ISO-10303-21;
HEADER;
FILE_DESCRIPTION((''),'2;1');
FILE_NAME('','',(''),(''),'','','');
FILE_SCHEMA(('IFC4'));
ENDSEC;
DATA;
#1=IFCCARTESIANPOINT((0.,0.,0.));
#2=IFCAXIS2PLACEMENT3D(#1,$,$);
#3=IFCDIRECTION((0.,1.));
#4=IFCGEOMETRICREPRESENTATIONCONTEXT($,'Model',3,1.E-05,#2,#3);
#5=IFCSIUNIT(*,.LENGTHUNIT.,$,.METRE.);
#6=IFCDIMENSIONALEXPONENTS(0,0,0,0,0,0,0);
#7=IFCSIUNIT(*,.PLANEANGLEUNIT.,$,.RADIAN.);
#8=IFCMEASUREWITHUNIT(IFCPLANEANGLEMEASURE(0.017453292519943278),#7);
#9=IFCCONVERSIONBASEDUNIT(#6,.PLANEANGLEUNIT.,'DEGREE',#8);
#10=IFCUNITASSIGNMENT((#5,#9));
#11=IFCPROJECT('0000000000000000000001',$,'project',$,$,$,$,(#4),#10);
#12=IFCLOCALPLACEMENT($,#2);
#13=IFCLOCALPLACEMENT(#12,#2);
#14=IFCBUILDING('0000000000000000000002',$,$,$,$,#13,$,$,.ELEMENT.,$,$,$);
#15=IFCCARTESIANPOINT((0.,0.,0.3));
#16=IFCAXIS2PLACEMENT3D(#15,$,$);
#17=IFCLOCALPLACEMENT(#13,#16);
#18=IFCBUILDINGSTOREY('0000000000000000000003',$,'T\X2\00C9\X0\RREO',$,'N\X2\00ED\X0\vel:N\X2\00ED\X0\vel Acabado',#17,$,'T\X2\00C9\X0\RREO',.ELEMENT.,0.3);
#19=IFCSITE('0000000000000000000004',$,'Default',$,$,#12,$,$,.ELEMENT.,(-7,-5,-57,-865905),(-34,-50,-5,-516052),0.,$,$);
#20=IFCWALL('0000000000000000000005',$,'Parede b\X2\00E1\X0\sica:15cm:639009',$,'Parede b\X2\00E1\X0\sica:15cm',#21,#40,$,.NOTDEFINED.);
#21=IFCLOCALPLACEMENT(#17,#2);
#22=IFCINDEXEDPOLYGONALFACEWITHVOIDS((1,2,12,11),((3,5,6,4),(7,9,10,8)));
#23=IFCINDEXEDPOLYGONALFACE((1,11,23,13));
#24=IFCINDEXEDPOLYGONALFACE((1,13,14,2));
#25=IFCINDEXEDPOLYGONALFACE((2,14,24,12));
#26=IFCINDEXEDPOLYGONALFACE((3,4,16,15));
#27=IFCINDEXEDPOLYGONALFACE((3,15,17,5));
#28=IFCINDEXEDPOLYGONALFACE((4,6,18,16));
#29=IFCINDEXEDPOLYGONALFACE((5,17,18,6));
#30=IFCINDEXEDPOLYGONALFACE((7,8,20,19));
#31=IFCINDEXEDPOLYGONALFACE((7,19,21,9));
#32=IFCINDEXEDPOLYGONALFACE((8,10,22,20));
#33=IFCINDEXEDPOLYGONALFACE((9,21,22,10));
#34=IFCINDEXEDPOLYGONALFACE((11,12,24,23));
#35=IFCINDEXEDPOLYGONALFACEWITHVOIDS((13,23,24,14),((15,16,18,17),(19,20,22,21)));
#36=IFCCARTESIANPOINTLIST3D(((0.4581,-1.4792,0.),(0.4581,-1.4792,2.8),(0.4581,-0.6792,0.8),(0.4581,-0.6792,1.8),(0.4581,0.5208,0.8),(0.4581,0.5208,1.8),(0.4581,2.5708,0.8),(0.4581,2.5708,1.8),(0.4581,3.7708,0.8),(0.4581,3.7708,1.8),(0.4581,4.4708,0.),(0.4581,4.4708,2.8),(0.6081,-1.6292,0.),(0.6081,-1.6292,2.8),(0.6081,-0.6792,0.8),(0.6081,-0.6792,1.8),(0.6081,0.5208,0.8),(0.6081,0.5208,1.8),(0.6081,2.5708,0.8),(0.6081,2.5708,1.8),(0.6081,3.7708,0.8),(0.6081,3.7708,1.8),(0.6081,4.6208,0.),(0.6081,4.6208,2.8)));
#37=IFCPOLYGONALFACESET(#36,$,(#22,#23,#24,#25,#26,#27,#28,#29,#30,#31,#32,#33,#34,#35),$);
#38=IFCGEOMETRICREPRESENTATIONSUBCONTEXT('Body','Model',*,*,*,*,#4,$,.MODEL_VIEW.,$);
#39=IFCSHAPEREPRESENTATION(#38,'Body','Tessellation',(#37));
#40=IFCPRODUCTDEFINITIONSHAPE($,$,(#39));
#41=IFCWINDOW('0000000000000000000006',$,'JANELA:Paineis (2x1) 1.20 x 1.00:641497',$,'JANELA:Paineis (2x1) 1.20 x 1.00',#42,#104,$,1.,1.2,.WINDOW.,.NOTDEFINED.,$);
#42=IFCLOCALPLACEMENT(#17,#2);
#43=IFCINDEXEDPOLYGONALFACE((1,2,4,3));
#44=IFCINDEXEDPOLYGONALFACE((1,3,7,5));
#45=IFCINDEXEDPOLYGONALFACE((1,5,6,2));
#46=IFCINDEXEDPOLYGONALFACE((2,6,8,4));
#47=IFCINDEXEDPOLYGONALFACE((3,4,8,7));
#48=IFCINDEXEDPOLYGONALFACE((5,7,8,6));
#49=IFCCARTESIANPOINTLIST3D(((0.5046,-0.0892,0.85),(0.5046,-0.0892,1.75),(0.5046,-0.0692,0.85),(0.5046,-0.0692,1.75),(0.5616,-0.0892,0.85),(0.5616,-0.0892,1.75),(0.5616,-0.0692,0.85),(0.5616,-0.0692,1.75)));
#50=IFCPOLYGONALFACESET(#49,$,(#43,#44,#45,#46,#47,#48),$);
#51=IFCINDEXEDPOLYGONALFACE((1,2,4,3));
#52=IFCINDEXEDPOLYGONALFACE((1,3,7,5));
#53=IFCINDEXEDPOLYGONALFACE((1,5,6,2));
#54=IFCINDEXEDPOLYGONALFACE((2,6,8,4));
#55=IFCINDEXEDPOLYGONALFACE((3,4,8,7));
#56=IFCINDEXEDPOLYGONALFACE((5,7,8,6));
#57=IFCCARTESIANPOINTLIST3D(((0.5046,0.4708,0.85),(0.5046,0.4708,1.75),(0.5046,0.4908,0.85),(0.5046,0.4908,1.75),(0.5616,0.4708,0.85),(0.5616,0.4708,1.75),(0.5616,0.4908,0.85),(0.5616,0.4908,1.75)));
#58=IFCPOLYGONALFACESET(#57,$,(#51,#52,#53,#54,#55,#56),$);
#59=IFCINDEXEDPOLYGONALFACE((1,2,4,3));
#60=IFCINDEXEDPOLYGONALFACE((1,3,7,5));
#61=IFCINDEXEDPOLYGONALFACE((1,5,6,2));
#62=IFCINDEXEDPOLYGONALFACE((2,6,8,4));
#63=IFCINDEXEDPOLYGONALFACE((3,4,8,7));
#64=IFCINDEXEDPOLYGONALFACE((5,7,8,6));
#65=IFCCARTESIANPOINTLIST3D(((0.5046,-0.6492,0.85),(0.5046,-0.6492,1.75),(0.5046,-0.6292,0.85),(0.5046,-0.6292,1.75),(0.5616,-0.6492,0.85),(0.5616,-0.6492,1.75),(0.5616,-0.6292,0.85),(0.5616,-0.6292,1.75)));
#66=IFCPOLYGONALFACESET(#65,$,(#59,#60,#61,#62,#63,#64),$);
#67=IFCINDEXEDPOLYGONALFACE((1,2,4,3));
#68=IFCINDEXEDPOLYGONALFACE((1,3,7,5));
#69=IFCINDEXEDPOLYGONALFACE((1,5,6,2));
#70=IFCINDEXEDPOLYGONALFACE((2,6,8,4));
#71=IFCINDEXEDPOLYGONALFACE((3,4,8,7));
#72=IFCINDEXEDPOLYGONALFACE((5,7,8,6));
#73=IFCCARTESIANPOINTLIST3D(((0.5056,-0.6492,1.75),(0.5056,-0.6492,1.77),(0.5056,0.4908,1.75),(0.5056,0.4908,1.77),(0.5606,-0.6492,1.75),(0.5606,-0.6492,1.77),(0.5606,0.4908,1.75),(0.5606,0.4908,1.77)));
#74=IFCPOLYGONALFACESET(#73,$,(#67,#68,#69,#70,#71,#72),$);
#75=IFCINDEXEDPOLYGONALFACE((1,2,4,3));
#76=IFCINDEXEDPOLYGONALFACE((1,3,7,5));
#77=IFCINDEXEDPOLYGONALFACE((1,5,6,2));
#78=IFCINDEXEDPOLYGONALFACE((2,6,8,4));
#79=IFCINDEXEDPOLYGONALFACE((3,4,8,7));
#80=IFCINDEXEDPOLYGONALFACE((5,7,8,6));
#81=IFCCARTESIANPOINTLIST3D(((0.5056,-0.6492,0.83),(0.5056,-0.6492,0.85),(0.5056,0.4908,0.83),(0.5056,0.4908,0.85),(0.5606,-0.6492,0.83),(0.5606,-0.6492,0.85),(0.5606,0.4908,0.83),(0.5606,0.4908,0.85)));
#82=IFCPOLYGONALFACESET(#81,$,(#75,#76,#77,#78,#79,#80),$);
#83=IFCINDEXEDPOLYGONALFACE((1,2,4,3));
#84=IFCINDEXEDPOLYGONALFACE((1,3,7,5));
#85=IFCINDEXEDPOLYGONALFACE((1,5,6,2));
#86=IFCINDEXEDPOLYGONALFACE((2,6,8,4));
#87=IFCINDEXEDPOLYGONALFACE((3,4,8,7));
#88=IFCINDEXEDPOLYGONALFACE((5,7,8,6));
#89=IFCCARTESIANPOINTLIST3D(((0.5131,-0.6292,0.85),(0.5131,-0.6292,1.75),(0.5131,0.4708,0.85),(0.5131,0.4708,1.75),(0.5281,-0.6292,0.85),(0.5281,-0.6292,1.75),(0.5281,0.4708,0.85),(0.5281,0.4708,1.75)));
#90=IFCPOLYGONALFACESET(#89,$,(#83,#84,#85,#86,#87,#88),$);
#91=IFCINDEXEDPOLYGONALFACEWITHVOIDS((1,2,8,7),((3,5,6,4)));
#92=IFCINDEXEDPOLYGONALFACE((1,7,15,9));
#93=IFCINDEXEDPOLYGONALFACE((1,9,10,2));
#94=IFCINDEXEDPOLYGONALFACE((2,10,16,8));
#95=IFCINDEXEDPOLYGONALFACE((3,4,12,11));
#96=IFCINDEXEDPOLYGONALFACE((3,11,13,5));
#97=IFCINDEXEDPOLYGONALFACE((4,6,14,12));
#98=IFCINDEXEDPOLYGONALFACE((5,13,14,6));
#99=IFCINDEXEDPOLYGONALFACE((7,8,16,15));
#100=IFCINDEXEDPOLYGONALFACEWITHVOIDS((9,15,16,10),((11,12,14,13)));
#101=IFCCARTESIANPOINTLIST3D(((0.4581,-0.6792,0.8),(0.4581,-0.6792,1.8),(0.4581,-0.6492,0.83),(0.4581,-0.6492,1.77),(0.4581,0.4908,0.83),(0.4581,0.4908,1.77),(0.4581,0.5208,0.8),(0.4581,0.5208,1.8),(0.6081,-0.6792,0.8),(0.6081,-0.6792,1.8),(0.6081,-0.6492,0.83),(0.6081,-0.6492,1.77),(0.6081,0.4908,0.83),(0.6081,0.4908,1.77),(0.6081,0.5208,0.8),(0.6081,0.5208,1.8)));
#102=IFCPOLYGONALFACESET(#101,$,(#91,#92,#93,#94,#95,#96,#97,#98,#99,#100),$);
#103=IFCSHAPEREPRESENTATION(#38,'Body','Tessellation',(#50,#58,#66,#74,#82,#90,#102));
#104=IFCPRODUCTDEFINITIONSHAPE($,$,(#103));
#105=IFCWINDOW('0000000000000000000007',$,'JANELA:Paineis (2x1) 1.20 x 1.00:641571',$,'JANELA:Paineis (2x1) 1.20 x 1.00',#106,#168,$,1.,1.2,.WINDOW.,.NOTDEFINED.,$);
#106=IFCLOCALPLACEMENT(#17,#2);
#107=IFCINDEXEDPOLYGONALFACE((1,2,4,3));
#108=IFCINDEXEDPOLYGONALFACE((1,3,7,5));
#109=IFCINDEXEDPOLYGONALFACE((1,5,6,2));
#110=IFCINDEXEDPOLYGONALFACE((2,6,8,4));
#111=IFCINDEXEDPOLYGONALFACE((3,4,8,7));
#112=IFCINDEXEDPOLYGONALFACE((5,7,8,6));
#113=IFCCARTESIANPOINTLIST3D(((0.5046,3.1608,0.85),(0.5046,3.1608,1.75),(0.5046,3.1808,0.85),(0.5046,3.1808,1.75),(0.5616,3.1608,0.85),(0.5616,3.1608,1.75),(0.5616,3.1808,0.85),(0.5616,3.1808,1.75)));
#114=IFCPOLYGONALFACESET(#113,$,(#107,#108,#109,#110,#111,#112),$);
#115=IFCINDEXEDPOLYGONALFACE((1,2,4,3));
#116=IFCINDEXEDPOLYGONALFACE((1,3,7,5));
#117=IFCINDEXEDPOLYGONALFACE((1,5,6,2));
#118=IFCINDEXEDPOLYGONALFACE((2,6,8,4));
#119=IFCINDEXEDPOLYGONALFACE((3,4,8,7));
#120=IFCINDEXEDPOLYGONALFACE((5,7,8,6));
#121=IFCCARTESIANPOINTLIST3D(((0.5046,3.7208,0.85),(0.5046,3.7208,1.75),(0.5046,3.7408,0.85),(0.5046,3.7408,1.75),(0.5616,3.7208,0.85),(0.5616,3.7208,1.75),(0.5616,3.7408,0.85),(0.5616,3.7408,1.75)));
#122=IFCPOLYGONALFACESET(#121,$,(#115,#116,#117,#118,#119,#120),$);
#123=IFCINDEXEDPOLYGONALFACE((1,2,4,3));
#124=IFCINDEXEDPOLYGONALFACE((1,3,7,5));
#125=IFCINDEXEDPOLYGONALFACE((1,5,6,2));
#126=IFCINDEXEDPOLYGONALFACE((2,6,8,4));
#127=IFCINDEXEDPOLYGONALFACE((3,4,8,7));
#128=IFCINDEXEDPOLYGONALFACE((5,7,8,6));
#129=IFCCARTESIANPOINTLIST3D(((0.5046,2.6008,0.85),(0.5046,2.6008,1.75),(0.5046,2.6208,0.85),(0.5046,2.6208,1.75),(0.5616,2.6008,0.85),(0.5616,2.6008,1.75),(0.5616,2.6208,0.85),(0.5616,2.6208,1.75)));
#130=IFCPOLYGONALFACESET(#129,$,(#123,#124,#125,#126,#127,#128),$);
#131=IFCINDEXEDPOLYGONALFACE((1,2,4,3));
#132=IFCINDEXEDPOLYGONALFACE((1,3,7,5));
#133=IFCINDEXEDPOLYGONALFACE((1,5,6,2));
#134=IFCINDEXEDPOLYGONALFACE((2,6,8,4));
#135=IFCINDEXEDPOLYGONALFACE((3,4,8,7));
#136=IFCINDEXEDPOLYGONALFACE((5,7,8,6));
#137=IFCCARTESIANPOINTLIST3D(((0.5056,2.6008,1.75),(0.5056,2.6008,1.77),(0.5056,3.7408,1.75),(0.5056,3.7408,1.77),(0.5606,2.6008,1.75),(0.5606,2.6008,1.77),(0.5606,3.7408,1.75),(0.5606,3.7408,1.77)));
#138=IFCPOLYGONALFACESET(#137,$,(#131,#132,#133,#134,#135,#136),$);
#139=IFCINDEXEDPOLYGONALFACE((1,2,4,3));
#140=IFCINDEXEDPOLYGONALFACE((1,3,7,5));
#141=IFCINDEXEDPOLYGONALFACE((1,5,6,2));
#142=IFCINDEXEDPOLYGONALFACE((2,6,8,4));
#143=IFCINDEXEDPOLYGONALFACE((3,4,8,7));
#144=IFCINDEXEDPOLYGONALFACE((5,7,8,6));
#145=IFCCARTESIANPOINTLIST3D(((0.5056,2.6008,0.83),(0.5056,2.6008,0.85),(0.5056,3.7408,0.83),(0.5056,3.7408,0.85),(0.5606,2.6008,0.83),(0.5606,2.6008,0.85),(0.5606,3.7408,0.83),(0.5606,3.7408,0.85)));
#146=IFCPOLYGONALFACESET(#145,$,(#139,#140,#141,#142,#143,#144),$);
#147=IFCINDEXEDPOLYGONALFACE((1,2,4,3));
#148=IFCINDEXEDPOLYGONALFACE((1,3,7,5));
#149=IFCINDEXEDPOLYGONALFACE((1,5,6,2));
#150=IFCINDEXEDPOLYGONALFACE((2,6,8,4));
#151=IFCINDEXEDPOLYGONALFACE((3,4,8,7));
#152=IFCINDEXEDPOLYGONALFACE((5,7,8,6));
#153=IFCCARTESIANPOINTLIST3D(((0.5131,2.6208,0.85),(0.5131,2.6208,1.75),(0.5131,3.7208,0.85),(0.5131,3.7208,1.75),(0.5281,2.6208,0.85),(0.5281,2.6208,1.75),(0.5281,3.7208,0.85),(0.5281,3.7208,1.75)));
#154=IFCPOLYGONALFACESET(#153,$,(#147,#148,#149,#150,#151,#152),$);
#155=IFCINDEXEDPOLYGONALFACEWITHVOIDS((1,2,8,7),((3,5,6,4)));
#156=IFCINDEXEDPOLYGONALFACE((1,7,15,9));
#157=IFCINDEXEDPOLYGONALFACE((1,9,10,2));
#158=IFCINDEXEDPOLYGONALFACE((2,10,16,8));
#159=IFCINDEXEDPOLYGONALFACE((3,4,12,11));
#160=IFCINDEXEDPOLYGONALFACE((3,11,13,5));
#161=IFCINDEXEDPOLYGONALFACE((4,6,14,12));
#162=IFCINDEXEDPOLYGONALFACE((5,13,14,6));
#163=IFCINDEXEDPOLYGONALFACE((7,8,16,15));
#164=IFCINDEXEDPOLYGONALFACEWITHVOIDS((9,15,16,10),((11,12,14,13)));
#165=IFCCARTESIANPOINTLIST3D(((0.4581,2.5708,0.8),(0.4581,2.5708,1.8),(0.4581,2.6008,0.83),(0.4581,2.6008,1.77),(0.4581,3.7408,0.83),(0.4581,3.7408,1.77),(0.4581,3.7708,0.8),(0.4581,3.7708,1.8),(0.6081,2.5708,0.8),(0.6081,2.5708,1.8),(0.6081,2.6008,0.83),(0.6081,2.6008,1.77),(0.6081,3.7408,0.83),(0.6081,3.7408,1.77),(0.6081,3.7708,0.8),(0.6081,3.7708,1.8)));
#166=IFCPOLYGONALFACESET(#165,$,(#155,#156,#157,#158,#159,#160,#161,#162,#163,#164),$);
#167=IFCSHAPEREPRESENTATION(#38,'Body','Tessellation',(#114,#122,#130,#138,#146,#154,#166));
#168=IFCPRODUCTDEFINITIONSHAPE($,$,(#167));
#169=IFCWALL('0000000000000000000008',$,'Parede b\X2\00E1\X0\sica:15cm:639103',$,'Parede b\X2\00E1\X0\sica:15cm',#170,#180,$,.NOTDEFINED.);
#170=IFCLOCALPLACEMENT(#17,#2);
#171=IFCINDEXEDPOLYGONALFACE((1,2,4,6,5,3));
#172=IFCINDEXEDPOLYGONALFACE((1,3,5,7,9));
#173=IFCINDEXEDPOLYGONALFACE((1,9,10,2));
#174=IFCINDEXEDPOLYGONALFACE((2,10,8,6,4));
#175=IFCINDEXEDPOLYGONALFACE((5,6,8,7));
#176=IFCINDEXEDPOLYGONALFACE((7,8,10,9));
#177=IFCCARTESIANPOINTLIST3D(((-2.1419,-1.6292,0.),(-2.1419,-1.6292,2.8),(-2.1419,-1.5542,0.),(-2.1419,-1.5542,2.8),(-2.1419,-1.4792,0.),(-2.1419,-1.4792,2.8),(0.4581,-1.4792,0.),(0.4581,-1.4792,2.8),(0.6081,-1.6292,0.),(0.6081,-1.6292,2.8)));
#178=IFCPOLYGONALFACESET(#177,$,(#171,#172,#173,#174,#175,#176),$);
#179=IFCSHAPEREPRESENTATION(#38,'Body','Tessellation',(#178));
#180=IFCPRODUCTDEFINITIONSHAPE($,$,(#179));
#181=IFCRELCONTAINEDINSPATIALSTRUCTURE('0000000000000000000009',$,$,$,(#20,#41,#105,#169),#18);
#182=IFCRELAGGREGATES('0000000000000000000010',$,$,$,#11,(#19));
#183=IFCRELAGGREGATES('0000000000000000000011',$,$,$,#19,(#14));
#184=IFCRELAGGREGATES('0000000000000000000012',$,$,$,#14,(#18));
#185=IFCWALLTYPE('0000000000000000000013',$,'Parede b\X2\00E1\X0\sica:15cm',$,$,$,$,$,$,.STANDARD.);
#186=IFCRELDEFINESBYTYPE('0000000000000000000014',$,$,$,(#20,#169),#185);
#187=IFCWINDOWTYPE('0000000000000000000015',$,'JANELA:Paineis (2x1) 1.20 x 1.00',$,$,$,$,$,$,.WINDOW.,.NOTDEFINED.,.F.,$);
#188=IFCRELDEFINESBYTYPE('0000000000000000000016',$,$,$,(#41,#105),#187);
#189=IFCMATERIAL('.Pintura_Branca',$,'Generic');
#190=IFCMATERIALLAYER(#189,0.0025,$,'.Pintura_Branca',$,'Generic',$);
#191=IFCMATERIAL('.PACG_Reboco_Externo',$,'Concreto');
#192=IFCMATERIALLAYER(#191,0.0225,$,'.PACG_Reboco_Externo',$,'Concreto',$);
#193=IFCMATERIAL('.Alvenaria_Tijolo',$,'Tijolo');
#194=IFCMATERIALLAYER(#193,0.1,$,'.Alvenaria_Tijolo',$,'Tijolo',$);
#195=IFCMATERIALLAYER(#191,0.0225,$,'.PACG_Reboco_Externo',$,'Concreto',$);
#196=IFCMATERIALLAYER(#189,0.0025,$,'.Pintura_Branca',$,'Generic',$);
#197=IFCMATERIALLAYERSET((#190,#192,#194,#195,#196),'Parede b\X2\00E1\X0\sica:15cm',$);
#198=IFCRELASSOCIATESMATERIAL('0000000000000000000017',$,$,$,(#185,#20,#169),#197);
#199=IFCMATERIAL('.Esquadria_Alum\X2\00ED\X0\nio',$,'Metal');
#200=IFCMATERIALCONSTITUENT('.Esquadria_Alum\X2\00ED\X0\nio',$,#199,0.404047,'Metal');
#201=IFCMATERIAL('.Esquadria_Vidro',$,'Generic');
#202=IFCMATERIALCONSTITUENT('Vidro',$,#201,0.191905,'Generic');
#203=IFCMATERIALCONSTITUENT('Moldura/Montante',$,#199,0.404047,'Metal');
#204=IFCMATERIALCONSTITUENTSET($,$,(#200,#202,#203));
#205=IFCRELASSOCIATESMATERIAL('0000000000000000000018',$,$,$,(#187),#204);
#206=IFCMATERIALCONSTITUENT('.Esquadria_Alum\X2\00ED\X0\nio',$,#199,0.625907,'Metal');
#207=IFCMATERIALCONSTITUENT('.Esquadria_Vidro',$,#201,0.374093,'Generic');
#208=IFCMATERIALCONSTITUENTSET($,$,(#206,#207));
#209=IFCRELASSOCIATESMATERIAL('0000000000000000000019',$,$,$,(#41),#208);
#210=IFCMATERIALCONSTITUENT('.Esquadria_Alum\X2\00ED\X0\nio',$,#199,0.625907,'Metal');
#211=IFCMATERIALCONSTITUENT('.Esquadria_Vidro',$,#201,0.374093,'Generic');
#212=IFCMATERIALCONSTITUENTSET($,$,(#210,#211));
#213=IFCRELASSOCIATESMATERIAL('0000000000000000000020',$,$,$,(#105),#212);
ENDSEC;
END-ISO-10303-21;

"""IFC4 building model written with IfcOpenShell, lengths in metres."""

from ifc_helpers import new_model, entity, si_unit, converted_unit, direction, frame, frame_2d, origin, origin_2d_with_axis, place, context, subcontext, project, spatial, polyline, rectangle, outline, extrude, source, transform, mapped, material, layer, layer_set, layer_usage, constituent, constituent_set, type_object, type_shapes, element, fill, save


model = new_model("IFC4")

# Units and contexts
model_context = context("Model", 3, precision=1e-05, world=origin(), true_north=direction((0.0, 1.0)))
body_context = subcontext(model_context, "Body", "Model", "MODEL_VIEW")
ifc_project = project(units=[si_unit("LENGTHUNIT", "METRE"), converted_unit("PLANEANGLEUNIT", "DEGREE", entity("IfcPlaneAngleMeasure", 0.017453292519943278), si_unit("PLANEANGLEUNIT", "RADIAN"), dimensions=[0, 0, 0, 0, 0, 0, 0])], contexts=[model_context])

# Site, building, storey
site_placement = place(None, origin())
site = spatial("IfcSite", under=ifc_project, at=site_placement, Name="Default", CompositionType="ELEMENT", RefLatitude=(-7, -5, -57, -865905), RefLongitude=(-34, -50, -5, -516052), RefElevation=0.0)
building_placement = place(site_placement, origin())
building = spatial("IfcBuilding", under=site, at=building_placement, CompositionType="ELEMENT")
storey_placement = place(building_placement, frame((0.0, 0.0, 0.3)))
storey = spatial("IfcBuildingStorey", under=building, at=storey_placement, Name="TÉRREO", ObjectType="Nível:Nível Acabado", LongName="TÉRREO", CompositionType="ELEMENT", Elevation=0.3)

# Shared definitions
ifc_material_1 = material(Name=".Pintura_Branca", Category="Generic")
ifc_layer_1 = layer(ifc_material_1, 0.0025, Name=".Pintura_Branca", Category="Generic")
ifc_material_2 = material(Name=".PACG_Reboco_Externo", Category="Concreto")
ifc_layer_2 = layer(ifc_material_2, 0.0225, Name=".PACG_Reboco_Externo", Category="Concreto")
ifc_material_3 = material(Name=".Alvenaria_Tijolo", Category="Tijolo")
ifc_layer_3 = layer(ifc_material_3, 0.1, Name=".Alvenaria_Tijolo", Category="Tijolo")
ifc_layer_4 = layer(ifc_material_2, 0.0225, Name=".PACG_Reboco_Externo", Category="Concreto")
ifc_layer_5 = layer(ifc_material_1, 0.0025, Name=".Pintura_Branca", Category="Generic")
ifc_layer_set_1 = layer_set([ifc_layer_1, ifc_layer_2, ifc_layer_3, ifc_layer_4, ifc_layer_5], Name="Parede básica:15cm")
wall_type = type_object("IfcWallType", Name="Parede básica:15cm", PredefinedType="STANDARD", material=ifc_layer_set_1)
ifc_material_4 = material(Name=".Esquadria_Alumínio", Category="Metal")
ifc_material_5 = material(Name=".Esquadria_Vidro", Category="Generic")

# Wall, openings, windows
ifc_layer_usage_1 = layer_usage(ifc_layer_set_1, "AXIS2", "NEGATIVE", 0.075)
wall_1_placement = place(storey_placement, frame((0.5331, 4.6208, 0.0), z_axis=(0.0, 0.0, 1.0), x_axis=(0.0, -1.0, 0.0)))
wall_1 = element("IfcWall", 1, at=wall_1_placement, inside=storey, type_object=wall_type, material=ifc_layer_usage_1, Name="Parede básica:15cm:639009", ObjectType="Parede básica:15cm", PredefinedType="NOTDEFINED", context=body_context, shape_type="SweptSolid", body=[
    extrude(outline(polyline([(6.1, -0.075), (6.25, 0.075), (0.0, 0.075), (0.15, -0.075), (3.0, -0.075), (3.15, -0.075), (6.1, -0.075)])), origin(), (0.0, 0.0, 1.0), 2.8),
])
opening_1_placement = place(wall_1_placement, frame((4.1, -0.075, 0.8)))
opening_1 = element("IfcOpeningElement", 2, at=opening_1_placement, cuts=wall_1, PredefinedType="OPENING", context=body_context, shape_type="SweptSolid", body=[
    extrude(rectangle(XDim=1.0, YDim=1.2, at=frame_2d((0.5, 0.6), x_axis=(1.0, 0.0))), frame((0.0, 0.0, 0.0), z_axis=(0.0, 1.0, 0.0), x_axis=(0.0, 0.0, 1.0)), (0.0, 0.0, 1.0), 0.15),
])
opening_2_placement = place(wall_1_placement, frame((0.85, -0.075, 0.8)))
opening_2 = element("IfcOpeningElement", 3, at=opening_2_placement, cuts=wall_1, PredefinedType="OPENING", context=body_context, shape_type="SweptSolid", body=[
    extrude(rectangle(XDim=1.0, YDim=1.2, at=frame_2d((0.5, 0.6), x_axis=(1.0, 0.0))), frame((0.0, 0.0, 0.0), z_axis=(0.0, 1.0, 0.0), x_axis=(0.0, 0.0, 1.0)), (0.0, 0.0, 1.0), 0.15),
])
ifc_constituent_1 = constituent(ifc_material_4, Name=".Esquadria_Alumínio", Category="Metal", fraction=0.625907)
ifc_constituent_2 = constituent(ifc_material_5, Name=".Esquadria_Vidro", Category="Generic", fraction=0.374093)
ifc_constituent_set_1 = constituent_set(constituents=[ifc_constituent_1, ifc_constituent_2])
ifc_constituent_3 = constituent(ifc_material_4, Name=".Esquadria_Alumínio", Category="Metal", fraction=0.404047)
ifc_constituent_4 = constituent(ifc_material_5, Name="Vidro", Category="Generic", fraction=0.191905)
ifc_constituent_5 = constituent(ifc_material_4, Name="Moldura/Montante", Category="Metal", fraction=0.404047)
ifc_constituent_set_2 = constituent_set(constituents=[ifc_constituent_3, ifc_constituent_4, ifc_constituent_5])
window_type_1 = type_object("IfcWindowType", Name="JANELA:Paineis (2x1) 1.20 x 1.00", ParameterTakesPrecedence=False, PartitioningType="NOTDEFINED", PredefinedType="WINDOW", material=ifc_constituent_set_2)
shared_shape_1 = source(origin(), body_context, "Body", "SweptSolid", [
    extrude(rectangle(XDim=0.02, YDim=0.057, at=origin_2d_with_axis()), frame((0.6, 0.075, 0.05), z_axis=(0.0, 0.0, 1.0), x_axis=(-1.0, 0.0, 0.0)), (0.0, 0.0, 1.0), 0.9),
    extrude(rectangle(XDim=0.02, YDim=0.057, at=frame_2d((0.0, 0.0), x_axis=(1.0, 0.0))), frame((0.04, 0.075, 0.05), z_axis=(0.0, 0.0, 1.0), x_axis=(-1.0, 0.0, 0.0)), (0.0, 0.0, 1.0), 0.9),
    extrude(rectangle(XDim=0.02, YDim=0.057, at=frame_2d((0.0, 0.0), x_axis=(1.0, 0.0))), frame((1.16, 0.075, 0.05), z_axis=(0.0, 0.0, 1.0), x_axis=(-1.0, 0.0, 0.0)), (0.0, 0.0, 1.0), 0.9),
    extrude(rectangle(XDim=1.14, YDim=0.055, at=frame_2d((0.0, 0.0), x_axis=(1.0, 0.0))), frame((0.6, 0.075, 0.95), z_axis=(0.0, 0.0, 1.0), x_axis=(-1.0, 0.0, 0.0)), (0.0, 0.0, 1.0), 0.02),
    extrude(rectangle(XDim=1.14, YDim=0.055, at=frame_2d((0.0, 0.0), x_axis=(1.0, 0.0))), frame((0.6, 0.075, 0.03), z_axis=(0.0, 0.0, 1.0), x_axis=(-1.0, 0.0, 0.0)), (0.0, 0.0, 1.0), 0.02),
    extrude(rectangle(XDim=0.015, YDim=1.1, at=frame_2d((0.0, 0.0), x_axis=(1.0, 0.0))), frame((0.6, 0.0625, 0.05), z_axis=(0.0, 0.0, 1.0), x_axis=(0.0, 1.0, 0.0)), (0.0, 0.0, 1.0), 0.9),
    extrude(outline(polyline([(-0.6, -0.5), (0.6, -0.5), (0.6, 0.5), (-0.6, 0.5), (-0.6, -0.5)]), holes=[polyline([(0.57, -0.47), (-0.57, -0.47), (-0.57, 0.47), (0.57, 0.47), (0.57, -0.47)])]), frame((0.6, 0.0, 0.5), z_axis=(0.0, 1.0, 0.0), x_axis=(1.0, 0.0, 0.0)), (0.0, 0.0, 1.0), 0.15),
])
type_shapes(window_type_1, [shared_shape_1])
window_1_placement = place(opening_1_placement, origin())
window_1 = element("IfcWindow", 4, at=window_1_placement, inside=storey, type_object=window_type_1, material=ifc_constituent_set_1, Name="JANELA:Paineis (2x1) 1.20 x 1.00:641497", ObjectType="JANELA:Paineis (2x1) 1.20 x 1.00", OverallHeight=1.0, OverallWidth=1.2, PartitioningType="NOTDEFINED", PredefinedType="WINDOW", context=body_context, shape_type="MappedRepresentation", body=[
    mapped(shared_shape_1, transform((0.0, 0.0, 0.0), scale=1.0)),
])
fill(opening_1, window_1)
ifc_constituent_6 = constituent(ifc_material_4, Name=".Esquadria_Alumínio", Category="Metal", fraction=0.625907)
ifc_constituent_7 = constituent(ifc_material_5, Name=".Esquadria_Vidro", Category="Generic", fraction=0.374093)
ifc_constituent_set_3 = constituent_set(constituents=[ifc_constituent_6, ifc_constituent_7])
window_2_placement = place(opening_2_placement, origin())
window_2 = element("IfcWindow", 5, at=window_2_placement, inside=storey, type_object=window_type_1, material=ifc_constituent_set_3, Name="JANELA:Paineis (2x1) 1.20 x 1.00:641571", ObjectType="JANELA:Paineis (2x1) 1.20 x 1.00", OverallHeight=1.0, OverallWidth=1.2, PartitioningType="NOTDEFINED", PredefinedType="WINDOW", context=body_context, shape_type="MappedRepresentation", body=[
    mapped(shared_shape_1, transform((0.0, 0.0, 0.0), scale=1.0)),
])
fill(opening_2, window_2)

# Wall
ifc_layer_usage_2 = layer_usage(ifc_layer_set_1, "AXIS2", "NEGATIVE", 0.075)
wall_2_placement = place(storey_placement, frame((0.6081, -1.5542, 0.0), z_axis=(0.0, 0.0, 1.0), x_axis=(-1.0, 0.0, 0.0)))
element("IfcWall", 6, at=wall_2_placement, inside=storey, type_object=wall_type, material=ifc_layer_usage_2, Name="Parede básica:15cm:639103", ObjectType="Parede básica:15cm", PredefinedType="NOTDEFINED", context=body_context, shape_type="SweptSolid", body=[
    extrude(outline(polyline([(2.75, -0.075), (2.75, 0.0), (2.75, 0.075), (0.0, 0.075), (0.15, -0.075), (2.75, -0.075)])), origin(), (0.0, 0.0, 1.0), 2.8),
])

save(model, "model.ifc")
